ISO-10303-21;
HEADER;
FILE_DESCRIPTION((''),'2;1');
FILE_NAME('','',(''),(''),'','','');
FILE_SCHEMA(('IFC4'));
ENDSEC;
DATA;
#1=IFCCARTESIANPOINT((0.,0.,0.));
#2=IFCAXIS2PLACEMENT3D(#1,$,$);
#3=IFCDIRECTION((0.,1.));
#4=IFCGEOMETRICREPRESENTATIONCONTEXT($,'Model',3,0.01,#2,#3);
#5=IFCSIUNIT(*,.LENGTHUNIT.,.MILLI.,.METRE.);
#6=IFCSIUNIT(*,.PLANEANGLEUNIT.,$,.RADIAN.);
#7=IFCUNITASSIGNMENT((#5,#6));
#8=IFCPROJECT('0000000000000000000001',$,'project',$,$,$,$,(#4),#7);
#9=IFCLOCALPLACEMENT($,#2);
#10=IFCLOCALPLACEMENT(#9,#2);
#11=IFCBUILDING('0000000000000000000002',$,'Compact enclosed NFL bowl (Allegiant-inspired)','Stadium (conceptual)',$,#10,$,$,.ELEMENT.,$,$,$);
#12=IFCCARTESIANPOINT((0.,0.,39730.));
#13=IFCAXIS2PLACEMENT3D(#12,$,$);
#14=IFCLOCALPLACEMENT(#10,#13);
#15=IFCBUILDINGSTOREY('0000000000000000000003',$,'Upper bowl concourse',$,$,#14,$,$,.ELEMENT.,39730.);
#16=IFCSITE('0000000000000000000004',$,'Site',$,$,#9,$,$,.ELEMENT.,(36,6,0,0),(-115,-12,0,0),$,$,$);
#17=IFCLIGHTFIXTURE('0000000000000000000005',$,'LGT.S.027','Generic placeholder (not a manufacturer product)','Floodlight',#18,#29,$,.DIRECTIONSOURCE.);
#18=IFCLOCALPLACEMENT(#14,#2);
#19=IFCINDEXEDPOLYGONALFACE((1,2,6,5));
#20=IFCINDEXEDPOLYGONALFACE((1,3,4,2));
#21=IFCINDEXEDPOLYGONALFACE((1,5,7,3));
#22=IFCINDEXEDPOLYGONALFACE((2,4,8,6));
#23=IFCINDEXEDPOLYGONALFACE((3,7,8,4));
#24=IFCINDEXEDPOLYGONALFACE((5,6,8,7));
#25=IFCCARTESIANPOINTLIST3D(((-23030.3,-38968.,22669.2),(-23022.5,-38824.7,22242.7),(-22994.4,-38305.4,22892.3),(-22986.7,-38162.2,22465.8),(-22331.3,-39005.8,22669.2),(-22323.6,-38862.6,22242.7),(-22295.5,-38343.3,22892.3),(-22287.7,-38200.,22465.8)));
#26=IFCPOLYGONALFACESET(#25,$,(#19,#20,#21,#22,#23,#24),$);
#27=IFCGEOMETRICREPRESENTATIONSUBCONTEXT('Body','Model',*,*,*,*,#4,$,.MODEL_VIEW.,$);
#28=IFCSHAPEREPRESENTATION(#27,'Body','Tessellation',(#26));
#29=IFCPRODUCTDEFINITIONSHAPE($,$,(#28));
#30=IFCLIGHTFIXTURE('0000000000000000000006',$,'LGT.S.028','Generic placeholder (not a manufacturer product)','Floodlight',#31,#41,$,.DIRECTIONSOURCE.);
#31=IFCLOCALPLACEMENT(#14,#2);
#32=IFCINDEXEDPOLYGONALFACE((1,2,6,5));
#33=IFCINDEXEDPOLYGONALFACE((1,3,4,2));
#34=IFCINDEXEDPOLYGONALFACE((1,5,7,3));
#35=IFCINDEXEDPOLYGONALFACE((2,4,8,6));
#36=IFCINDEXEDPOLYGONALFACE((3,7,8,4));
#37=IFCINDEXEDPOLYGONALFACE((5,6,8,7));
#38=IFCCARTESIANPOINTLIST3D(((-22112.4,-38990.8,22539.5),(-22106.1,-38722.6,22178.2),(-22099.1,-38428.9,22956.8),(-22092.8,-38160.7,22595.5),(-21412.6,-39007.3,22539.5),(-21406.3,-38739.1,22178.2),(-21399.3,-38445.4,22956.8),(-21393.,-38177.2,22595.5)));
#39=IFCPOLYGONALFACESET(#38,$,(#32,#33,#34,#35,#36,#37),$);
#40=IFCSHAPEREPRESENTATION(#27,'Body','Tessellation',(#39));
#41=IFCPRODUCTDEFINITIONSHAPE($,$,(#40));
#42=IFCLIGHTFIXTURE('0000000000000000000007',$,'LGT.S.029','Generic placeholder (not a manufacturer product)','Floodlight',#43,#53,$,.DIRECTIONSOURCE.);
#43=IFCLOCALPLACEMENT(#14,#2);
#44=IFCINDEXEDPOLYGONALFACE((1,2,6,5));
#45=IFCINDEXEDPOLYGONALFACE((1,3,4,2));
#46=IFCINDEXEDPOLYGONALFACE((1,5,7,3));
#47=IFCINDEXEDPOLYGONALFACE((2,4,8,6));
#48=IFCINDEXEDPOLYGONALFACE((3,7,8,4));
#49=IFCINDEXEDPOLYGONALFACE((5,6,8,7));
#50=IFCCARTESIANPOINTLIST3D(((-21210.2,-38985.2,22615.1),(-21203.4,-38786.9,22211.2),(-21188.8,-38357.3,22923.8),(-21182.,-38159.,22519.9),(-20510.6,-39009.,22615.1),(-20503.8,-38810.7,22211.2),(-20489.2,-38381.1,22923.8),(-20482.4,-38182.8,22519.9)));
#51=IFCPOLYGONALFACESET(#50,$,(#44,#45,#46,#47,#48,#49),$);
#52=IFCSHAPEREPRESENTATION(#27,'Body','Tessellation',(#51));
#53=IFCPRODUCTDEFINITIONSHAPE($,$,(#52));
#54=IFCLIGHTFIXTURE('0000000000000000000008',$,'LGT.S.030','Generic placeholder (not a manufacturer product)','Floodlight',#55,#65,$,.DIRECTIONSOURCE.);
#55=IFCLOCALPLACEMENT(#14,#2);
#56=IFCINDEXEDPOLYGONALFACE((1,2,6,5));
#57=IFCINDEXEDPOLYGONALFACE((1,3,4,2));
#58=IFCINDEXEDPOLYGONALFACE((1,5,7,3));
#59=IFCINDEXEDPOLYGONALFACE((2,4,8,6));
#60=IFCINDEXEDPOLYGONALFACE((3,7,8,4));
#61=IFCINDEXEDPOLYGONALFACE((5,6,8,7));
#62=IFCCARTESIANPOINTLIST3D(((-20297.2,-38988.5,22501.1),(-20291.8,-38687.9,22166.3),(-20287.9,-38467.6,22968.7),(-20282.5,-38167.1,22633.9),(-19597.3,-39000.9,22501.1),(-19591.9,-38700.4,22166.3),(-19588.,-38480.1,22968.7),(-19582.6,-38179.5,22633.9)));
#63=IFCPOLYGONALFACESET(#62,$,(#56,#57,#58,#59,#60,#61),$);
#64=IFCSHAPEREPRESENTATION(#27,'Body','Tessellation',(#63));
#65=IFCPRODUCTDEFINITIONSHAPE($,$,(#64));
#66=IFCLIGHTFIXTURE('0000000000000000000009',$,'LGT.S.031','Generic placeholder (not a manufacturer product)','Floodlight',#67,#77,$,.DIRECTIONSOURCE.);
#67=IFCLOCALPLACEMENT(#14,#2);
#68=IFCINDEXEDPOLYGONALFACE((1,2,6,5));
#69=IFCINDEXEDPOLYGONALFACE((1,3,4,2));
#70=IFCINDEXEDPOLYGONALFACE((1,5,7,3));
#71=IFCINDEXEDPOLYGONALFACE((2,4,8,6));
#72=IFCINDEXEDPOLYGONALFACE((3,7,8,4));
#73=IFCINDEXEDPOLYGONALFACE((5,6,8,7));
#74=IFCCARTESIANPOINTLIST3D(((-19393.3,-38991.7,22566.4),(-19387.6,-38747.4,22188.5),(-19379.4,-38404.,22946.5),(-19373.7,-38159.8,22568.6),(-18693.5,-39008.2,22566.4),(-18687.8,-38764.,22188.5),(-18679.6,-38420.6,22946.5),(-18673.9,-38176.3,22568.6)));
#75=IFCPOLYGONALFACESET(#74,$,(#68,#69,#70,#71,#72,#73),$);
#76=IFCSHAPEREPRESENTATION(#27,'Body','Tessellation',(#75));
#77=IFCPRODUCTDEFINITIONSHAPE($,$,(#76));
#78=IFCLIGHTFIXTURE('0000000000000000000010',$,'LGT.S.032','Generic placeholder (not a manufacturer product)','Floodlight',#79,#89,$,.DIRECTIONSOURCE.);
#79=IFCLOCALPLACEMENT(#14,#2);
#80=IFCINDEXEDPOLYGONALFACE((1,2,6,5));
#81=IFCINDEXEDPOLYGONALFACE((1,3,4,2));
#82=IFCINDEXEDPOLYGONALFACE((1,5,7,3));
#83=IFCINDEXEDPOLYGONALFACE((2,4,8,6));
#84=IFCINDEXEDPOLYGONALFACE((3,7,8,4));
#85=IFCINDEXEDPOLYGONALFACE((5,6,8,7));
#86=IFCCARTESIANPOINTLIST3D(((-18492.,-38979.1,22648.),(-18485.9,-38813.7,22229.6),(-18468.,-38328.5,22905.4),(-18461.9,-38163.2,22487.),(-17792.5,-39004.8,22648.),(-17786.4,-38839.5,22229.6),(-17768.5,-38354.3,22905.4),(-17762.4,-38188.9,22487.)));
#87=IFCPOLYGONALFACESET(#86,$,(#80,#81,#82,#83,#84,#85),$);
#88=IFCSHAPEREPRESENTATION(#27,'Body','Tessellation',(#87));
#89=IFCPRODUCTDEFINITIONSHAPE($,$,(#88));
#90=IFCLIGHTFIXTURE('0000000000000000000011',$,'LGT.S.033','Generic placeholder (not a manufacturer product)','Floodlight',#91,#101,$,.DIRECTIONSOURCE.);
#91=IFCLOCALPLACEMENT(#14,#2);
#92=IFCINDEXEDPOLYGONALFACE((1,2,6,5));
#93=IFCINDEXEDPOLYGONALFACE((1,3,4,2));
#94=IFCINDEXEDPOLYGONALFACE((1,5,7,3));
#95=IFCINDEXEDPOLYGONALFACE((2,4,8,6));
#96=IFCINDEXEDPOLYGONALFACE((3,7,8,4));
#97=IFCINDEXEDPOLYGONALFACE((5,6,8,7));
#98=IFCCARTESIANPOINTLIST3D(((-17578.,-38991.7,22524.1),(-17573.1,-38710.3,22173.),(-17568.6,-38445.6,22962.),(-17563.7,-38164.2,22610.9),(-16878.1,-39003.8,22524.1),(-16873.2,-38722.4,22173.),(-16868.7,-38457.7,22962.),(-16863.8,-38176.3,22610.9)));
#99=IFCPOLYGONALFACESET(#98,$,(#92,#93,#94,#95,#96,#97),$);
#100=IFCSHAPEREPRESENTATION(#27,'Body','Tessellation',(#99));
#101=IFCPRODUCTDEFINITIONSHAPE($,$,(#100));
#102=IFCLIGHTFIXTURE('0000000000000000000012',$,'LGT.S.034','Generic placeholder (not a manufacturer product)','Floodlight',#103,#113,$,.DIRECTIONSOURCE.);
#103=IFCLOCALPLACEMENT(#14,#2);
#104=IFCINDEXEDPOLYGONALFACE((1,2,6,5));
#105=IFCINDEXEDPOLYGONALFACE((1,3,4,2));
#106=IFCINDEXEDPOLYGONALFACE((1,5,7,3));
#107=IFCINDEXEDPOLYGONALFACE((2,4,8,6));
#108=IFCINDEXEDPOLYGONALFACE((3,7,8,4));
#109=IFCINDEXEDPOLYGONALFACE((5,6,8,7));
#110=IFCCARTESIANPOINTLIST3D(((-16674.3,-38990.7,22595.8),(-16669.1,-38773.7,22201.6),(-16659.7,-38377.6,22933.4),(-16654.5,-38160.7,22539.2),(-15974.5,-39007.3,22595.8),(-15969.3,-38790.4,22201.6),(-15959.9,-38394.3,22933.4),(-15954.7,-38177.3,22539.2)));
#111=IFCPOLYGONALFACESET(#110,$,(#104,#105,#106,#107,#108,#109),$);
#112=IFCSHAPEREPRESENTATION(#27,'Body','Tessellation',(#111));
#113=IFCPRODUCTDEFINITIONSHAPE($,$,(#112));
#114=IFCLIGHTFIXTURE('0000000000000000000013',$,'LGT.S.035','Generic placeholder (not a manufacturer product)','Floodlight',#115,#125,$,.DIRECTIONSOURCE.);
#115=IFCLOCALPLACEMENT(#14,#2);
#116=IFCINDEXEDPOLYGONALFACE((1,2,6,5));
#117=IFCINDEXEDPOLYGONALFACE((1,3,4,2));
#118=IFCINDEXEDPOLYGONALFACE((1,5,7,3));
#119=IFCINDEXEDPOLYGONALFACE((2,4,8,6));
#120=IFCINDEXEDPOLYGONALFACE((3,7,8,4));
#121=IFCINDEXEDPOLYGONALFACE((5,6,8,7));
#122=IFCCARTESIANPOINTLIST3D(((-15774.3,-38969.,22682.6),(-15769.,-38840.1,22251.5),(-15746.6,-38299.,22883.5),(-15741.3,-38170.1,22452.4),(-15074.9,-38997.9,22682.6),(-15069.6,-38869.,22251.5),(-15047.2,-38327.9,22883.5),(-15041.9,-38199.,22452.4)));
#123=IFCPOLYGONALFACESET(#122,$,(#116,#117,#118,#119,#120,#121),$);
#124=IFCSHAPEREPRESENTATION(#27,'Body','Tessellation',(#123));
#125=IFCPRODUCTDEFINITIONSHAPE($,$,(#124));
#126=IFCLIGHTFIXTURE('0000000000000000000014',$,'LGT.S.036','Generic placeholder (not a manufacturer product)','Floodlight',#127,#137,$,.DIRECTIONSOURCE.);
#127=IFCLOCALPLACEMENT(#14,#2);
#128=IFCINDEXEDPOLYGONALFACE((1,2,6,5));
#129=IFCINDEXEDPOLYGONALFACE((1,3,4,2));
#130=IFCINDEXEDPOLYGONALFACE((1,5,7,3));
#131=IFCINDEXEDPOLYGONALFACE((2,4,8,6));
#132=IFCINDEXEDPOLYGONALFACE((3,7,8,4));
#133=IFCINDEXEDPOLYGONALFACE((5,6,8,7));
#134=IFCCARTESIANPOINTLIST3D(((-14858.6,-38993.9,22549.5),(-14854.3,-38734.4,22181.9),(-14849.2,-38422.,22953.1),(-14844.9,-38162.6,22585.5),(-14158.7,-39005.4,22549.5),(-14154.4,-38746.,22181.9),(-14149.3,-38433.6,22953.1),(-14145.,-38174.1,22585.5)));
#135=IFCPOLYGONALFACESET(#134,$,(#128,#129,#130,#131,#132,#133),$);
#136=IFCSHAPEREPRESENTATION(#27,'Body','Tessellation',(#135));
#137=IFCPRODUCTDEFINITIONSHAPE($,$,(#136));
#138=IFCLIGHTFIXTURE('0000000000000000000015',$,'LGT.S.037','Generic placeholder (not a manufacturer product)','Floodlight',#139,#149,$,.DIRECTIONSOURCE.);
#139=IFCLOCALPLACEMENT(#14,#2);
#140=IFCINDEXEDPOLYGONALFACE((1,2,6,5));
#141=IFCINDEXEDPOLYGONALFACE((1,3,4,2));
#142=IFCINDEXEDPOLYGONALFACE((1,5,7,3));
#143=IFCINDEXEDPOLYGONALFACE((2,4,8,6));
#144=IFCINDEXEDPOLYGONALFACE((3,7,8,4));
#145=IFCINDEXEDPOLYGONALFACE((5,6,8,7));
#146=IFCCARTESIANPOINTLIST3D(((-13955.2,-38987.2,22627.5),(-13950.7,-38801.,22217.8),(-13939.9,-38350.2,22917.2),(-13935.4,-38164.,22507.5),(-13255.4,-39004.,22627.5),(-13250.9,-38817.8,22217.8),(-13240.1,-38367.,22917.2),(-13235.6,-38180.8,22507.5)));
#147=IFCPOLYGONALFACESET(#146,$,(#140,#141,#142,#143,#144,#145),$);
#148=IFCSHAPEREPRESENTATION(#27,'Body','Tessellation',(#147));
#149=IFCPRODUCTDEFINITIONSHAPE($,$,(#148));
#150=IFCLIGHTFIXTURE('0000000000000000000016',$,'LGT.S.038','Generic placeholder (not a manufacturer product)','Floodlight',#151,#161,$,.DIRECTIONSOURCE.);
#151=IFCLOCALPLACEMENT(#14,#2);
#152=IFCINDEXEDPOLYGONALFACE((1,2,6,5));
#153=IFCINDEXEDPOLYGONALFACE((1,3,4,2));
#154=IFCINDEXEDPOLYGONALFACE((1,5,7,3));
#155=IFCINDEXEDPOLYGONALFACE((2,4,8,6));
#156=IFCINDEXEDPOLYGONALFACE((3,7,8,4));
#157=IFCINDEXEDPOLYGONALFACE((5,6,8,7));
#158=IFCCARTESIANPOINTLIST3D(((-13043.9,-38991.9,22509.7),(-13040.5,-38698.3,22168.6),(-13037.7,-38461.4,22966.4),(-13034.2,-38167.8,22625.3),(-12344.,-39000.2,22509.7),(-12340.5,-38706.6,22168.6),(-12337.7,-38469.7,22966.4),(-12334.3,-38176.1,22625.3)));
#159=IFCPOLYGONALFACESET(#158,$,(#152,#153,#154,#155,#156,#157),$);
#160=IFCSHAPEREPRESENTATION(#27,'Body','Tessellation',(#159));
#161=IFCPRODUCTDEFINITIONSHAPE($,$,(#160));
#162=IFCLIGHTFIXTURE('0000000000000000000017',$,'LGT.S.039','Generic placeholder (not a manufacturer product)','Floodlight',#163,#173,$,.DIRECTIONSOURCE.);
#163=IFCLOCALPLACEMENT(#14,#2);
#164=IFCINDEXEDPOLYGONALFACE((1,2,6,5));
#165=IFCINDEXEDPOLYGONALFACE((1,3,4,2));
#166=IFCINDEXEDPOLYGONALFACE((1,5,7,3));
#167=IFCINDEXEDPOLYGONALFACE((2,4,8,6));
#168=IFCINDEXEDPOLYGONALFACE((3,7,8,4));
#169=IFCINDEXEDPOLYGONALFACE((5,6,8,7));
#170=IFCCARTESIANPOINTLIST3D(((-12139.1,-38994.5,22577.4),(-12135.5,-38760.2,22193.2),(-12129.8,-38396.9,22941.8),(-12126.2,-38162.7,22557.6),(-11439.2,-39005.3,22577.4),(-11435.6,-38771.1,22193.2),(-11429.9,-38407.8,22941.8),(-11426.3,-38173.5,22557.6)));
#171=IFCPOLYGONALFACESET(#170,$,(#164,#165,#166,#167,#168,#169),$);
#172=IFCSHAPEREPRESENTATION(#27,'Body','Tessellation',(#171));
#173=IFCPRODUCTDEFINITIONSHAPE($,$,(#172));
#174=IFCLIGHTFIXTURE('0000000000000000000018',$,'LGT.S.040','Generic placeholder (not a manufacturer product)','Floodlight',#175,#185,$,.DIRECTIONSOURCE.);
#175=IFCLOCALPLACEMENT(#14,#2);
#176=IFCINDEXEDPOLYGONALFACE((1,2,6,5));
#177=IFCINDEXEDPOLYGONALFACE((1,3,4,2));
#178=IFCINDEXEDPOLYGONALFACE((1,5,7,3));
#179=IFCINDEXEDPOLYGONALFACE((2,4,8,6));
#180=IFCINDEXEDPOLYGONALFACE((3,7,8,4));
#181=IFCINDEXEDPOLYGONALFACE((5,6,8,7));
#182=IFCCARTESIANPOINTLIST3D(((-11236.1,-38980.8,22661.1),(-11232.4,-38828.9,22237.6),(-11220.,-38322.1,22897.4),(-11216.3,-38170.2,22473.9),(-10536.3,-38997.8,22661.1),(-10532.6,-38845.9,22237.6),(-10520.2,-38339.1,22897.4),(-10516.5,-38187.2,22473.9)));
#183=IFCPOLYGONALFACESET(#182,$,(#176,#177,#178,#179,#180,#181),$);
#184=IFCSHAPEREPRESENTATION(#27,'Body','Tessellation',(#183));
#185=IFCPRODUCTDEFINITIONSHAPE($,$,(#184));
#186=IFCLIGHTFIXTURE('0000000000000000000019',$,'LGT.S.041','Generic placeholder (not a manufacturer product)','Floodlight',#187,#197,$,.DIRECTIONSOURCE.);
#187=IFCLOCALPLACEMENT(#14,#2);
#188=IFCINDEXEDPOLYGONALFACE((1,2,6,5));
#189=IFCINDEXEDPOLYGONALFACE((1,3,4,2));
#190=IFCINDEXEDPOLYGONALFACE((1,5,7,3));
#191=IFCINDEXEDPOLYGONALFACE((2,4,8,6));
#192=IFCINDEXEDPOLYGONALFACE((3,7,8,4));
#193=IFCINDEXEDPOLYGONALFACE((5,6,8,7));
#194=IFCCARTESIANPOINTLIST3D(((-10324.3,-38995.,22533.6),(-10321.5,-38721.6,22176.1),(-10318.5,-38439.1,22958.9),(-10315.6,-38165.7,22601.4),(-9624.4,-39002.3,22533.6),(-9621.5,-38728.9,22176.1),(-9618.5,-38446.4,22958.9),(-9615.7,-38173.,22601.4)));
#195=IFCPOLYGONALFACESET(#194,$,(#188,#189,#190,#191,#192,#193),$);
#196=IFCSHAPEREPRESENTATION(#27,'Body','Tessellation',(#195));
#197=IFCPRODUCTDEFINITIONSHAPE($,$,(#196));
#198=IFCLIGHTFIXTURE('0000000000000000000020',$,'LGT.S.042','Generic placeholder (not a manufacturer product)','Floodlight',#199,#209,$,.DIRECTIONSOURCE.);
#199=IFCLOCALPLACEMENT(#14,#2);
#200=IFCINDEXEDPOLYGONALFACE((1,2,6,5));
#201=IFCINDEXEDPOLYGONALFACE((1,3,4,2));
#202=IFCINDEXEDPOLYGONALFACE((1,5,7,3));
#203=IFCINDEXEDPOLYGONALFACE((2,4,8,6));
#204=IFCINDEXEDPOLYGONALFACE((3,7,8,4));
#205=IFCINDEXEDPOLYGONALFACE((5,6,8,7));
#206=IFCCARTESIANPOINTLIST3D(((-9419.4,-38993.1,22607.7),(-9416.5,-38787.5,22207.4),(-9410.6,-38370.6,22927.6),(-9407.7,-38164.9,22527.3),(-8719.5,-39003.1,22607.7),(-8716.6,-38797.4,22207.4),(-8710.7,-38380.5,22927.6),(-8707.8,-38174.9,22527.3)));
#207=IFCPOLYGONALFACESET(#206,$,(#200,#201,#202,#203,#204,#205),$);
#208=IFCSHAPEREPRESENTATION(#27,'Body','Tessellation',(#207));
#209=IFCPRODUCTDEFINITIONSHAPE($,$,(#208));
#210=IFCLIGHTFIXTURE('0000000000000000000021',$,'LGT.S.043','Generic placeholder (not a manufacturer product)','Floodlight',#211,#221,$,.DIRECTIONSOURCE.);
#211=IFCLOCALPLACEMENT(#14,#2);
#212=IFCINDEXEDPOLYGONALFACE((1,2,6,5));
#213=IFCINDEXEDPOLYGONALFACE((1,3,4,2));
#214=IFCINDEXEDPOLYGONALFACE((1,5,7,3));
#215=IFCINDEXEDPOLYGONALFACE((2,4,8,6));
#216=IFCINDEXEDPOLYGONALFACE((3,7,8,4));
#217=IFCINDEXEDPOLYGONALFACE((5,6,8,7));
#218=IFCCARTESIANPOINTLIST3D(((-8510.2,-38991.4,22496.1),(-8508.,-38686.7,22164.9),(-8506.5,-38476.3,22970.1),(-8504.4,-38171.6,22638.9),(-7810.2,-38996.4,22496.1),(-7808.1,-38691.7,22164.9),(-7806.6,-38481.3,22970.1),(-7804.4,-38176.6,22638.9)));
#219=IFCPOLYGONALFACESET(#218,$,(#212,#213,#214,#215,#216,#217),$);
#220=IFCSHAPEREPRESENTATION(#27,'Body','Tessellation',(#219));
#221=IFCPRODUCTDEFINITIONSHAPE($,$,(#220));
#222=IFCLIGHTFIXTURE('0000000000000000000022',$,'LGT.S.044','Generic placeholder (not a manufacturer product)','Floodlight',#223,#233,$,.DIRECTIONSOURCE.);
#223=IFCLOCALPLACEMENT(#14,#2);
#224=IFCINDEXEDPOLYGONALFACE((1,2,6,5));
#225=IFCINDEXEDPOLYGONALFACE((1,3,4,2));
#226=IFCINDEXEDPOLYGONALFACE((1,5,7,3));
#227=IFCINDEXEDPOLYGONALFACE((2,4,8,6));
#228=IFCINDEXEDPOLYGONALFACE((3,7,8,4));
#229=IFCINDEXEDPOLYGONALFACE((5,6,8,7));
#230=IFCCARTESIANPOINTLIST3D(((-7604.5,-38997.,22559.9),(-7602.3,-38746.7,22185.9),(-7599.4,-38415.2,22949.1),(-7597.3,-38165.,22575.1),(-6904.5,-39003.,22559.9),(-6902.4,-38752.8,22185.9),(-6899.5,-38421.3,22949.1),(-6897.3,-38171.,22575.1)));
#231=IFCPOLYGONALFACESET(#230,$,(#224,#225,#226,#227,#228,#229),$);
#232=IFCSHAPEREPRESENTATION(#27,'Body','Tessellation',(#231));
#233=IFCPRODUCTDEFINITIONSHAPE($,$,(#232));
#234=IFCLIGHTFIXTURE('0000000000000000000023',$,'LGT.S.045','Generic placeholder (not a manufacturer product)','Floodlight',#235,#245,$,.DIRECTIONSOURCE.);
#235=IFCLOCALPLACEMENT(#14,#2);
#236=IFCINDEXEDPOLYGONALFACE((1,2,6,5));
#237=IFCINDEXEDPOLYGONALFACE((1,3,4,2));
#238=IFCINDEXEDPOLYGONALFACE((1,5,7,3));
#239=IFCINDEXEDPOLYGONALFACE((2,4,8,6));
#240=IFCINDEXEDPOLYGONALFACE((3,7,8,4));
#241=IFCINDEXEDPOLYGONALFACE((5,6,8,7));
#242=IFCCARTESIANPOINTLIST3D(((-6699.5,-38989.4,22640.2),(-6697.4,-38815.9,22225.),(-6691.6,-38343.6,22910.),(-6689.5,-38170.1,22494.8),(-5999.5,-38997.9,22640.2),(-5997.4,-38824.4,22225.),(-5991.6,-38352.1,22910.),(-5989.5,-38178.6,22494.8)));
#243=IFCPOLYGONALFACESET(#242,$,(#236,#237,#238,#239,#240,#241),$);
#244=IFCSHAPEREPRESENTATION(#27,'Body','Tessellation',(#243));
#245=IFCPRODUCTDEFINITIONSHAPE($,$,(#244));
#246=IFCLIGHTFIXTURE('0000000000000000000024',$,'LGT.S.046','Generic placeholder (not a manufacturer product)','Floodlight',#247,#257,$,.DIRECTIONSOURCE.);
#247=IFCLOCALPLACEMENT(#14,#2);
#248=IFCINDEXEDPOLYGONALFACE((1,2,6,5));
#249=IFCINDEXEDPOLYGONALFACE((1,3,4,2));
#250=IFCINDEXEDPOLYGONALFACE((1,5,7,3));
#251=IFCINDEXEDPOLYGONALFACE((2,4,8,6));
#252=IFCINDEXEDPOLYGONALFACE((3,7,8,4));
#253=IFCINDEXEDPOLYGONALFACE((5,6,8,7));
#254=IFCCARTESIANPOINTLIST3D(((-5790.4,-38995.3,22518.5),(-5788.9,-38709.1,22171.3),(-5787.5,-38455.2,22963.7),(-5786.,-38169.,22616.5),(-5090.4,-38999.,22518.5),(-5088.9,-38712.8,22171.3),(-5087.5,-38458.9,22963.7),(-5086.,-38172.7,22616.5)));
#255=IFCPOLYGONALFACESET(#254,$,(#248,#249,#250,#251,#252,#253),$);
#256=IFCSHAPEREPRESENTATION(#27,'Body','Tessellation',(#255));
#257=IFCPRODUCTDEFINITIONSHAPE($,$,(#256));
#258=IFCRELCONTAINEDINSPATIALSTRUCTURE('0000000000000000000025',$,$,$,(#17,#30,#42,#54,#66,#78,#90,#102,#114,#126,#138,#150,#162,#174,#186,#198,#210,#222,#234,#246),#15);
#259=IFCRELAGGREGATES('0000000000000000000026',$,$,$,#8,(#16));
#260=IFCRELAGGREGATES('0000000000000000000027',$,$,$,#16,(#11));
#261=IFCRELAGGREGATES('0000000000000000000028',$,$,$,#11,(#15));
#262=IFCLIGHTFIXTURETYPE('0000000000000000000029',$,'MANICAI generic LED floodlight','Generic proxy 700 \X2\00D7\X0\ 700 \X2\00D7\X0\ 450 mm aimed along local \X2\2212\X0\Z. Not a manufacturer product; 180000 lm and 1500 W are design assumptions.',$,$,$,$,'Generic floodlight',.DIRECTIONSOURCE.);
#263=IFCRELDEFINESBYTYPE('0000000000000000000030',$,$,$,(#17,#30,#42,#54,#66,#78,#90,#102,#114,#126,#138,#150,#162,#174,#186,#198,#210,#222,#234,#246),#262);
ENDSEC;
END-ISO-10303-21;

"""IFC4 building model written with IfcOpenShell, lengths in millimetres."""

from ifc_helpers import new_model, si_unit, direction, frame, origin, place, context, subcontext, project, spatial, rectangle, extrude, source, transform, mapped, type_object, type_shapes, element, save


model = new_model("IFC4")

# Units and contexts
model_context = context("Model", 3, precision=0.01, world=origin(), true_north=direction((0.0, 1.0)))
body_context = subcontext(model_context, "Body", "Model", "MODEL_VIEW")
ifc_project = project(units=[si_unit("LENGTHUNIT", "METRE", prefix="MILLI"), si_unit("PLANEANGLEUNIT", "RADIAN")], contexts=[model_context])

# Site, building, storey
site_placement = place(None, origin())
site = spatial("IfcSite", under=ifc_project, at=site_placement, Name="Site", CompositionType="ELEMENT", RefLatitude=(36, 6, 0, 0), RefLongitude=(-115, -12, 0, 0))
building_placement = place(site_placement, origin())
building = spatial("IfcBuilding", under=site, at=building_placement, Name="Compact enclosed NFL bowl (Allegiant-inspired)", Description="Stadium (conceptual)", CompositionType="ELEMENT")
storey_placement = place(building_placement, frame((0.0, 0.0, 39730.0)))
storey = spatial("IfcBuildingStorey", under=building, at=storey_placement, Name="Upper bowl concourse", CompositionType="ELEMENT", Elevation=39730.0)

# Light fixtures
light_fixture_type = type_object("IfcLightFixtureType", Name="MANICAI generic LED floodlight", Description="Generic proxy 700 × 700 × 450 mm aimed along local −Z. Not a manufacturer product; 180000 lm and 1500 W are design assumptions.", ElementType="Generic floodlight", PredefinedType="DIRECTIONSOURCE")
shared_shape = source(origin(), body_context, "Body", "SweptSolid", [
    extrude(rectangle(XDim=700.0, YDim=700.0), frame((0.0, 0.0, -225.0)), (0.0, 0.0, 1.0), 450.0),
])
type_shapes(light_fixture_type, [shared_shape])
for number, where, z_axis, x_axis, name in (
    (1, (-22659.0, -38584.0, 22567.5), (-0.017237, -0.318336, 0.947821), (0.998537, -0.054069, 0.0), "LGT.S.027"),
    (2, (-21752.7, -38584.0, 22567.5), (-0.014017, -0.595958, 0.802893), (0.999723, -0.023514, 0.0), "LGT.S.028"),
    (3, (-20846.3, -38584.0, 22567.5), (-0.015016, -0.440756, 0.897501), (0.99942, -0.03405, 0.0), "LGT.S.029"),
    (4, (-19939.9, -38584.0, 22567.5), (-0.01191, -0.667887, 0.744168), (0.999841, -0.017829, 0.0), "LGT.S.030"),
    (5, (-19033.6, -38584.0, 22567.5), (-0.012829, -0.542772, 0.839782), (0.999721, -0.023629, 0.0), "LGT.S.031"),
    (6, (-18127.2, -38584.0, 22567.5), (-0.01353, -0.367468, 0.929938), (0.999323, -0.036793, 0.0), "LGT.S.032"),
    (7, (-17220.9, -38584.0, 22567.5), (-0.010784, -0.625399, 0.780231), (0.999851, -0.017241, 0.0), "LGT.S.033"),
    (8, (-16314.5, -38584.0, 22567.5), (-0.011471, -0.482146, 0.876016), (0.999717, -0.023784, 0.0), "LGT.S.034"),
    (9, (-15408.1, -38584.0, 22567.5), (-0.011847, -0.286638, 0.957966), (0.999147, -0.041295, 0.0), "LGT.S.035"),
    (10, (-14501.8, -38584.0, 22567.5), (-0.00951, -0.576513, 0.817033), (0.999864, -0.016493, 0.0), "LGT.S.036"),
    (11, (-13595.4, -38584.0, 22567.5), (-0.009934, -0.413708, 0.910355), (0.999712, -0.024004, 0.0), "LGT.S.037"),
    (12, (-12689.1, -38584.0, 22567.5), (-0.007718, -0.65239, 0.757844), (0.99993, -0.01183, 0.0), "LGT.S.038"),
    (13, (-11782.7, -38584.0, 22567.5), (-0.008074, -0.520542, 0.853798), (0.99988, -0.015509, 0.0), "LGT.S.039"),
    (14, (-10876.3, -38584.0, 22567.5), (-0.008217, -0.337465, 0.941302), (0.999704, -0.024342, 0.0), "LGT.S.040"),
    (15, (-9970.0, -38584.0, 22567.5), (-0.006356, -0.607541, 0.794263), (0.999945, -0.010461, 0.0), "LGT.S.041"),
    (16, (-9063.6, -38584.0, 22567.5), (-0.00647, -0.456955, 0.889466), (0.9999, -0.014158, 0.0), "LGT.S.042"),
    (17, (-8157.3, -38584.0, 22567.5), (-0.004818, -0.677106, 0.73587), (0.999975, -0.007115, 0.0), "LGT.S.043"),
    (18, (-7250.9, -38584.0, 22567.5), (-0.004837, -0.55602, 0.831155), (0.999962, -0.008699, 0.0), "LGT.S.044"),
    (19, (-6344.5, -38584.0, 22567.5), (-0.004698, -0.385503, 0.922694), (0.999926, -0.012187, 0.0), "LGT.S.045"),
    (20, (-5438.2, -38584.0, 22567.5), (-0.003368, -0.636014, 0.77167), (0.999986, -0.005296, 0.0), "LGT.S.046"),
):
    element("IfcLightFixture", number, at=place(storey_placement, frame(where, z_axis=z_axis, x_axis=x_axis)), inside=storey, type_object=light_fixture_type, Name=name, Description="Generic placeholder (not a manufacturer product)", ObjectType="Floodlight", PredefinedType="DIRECTIONSOURCE", context=body_context, shape_type="MappedRepresentation", body=[
        mapped(shared_shape, transform((0.0, 0.0, 0.0))),
    ])

save(model, "model.ifc")
